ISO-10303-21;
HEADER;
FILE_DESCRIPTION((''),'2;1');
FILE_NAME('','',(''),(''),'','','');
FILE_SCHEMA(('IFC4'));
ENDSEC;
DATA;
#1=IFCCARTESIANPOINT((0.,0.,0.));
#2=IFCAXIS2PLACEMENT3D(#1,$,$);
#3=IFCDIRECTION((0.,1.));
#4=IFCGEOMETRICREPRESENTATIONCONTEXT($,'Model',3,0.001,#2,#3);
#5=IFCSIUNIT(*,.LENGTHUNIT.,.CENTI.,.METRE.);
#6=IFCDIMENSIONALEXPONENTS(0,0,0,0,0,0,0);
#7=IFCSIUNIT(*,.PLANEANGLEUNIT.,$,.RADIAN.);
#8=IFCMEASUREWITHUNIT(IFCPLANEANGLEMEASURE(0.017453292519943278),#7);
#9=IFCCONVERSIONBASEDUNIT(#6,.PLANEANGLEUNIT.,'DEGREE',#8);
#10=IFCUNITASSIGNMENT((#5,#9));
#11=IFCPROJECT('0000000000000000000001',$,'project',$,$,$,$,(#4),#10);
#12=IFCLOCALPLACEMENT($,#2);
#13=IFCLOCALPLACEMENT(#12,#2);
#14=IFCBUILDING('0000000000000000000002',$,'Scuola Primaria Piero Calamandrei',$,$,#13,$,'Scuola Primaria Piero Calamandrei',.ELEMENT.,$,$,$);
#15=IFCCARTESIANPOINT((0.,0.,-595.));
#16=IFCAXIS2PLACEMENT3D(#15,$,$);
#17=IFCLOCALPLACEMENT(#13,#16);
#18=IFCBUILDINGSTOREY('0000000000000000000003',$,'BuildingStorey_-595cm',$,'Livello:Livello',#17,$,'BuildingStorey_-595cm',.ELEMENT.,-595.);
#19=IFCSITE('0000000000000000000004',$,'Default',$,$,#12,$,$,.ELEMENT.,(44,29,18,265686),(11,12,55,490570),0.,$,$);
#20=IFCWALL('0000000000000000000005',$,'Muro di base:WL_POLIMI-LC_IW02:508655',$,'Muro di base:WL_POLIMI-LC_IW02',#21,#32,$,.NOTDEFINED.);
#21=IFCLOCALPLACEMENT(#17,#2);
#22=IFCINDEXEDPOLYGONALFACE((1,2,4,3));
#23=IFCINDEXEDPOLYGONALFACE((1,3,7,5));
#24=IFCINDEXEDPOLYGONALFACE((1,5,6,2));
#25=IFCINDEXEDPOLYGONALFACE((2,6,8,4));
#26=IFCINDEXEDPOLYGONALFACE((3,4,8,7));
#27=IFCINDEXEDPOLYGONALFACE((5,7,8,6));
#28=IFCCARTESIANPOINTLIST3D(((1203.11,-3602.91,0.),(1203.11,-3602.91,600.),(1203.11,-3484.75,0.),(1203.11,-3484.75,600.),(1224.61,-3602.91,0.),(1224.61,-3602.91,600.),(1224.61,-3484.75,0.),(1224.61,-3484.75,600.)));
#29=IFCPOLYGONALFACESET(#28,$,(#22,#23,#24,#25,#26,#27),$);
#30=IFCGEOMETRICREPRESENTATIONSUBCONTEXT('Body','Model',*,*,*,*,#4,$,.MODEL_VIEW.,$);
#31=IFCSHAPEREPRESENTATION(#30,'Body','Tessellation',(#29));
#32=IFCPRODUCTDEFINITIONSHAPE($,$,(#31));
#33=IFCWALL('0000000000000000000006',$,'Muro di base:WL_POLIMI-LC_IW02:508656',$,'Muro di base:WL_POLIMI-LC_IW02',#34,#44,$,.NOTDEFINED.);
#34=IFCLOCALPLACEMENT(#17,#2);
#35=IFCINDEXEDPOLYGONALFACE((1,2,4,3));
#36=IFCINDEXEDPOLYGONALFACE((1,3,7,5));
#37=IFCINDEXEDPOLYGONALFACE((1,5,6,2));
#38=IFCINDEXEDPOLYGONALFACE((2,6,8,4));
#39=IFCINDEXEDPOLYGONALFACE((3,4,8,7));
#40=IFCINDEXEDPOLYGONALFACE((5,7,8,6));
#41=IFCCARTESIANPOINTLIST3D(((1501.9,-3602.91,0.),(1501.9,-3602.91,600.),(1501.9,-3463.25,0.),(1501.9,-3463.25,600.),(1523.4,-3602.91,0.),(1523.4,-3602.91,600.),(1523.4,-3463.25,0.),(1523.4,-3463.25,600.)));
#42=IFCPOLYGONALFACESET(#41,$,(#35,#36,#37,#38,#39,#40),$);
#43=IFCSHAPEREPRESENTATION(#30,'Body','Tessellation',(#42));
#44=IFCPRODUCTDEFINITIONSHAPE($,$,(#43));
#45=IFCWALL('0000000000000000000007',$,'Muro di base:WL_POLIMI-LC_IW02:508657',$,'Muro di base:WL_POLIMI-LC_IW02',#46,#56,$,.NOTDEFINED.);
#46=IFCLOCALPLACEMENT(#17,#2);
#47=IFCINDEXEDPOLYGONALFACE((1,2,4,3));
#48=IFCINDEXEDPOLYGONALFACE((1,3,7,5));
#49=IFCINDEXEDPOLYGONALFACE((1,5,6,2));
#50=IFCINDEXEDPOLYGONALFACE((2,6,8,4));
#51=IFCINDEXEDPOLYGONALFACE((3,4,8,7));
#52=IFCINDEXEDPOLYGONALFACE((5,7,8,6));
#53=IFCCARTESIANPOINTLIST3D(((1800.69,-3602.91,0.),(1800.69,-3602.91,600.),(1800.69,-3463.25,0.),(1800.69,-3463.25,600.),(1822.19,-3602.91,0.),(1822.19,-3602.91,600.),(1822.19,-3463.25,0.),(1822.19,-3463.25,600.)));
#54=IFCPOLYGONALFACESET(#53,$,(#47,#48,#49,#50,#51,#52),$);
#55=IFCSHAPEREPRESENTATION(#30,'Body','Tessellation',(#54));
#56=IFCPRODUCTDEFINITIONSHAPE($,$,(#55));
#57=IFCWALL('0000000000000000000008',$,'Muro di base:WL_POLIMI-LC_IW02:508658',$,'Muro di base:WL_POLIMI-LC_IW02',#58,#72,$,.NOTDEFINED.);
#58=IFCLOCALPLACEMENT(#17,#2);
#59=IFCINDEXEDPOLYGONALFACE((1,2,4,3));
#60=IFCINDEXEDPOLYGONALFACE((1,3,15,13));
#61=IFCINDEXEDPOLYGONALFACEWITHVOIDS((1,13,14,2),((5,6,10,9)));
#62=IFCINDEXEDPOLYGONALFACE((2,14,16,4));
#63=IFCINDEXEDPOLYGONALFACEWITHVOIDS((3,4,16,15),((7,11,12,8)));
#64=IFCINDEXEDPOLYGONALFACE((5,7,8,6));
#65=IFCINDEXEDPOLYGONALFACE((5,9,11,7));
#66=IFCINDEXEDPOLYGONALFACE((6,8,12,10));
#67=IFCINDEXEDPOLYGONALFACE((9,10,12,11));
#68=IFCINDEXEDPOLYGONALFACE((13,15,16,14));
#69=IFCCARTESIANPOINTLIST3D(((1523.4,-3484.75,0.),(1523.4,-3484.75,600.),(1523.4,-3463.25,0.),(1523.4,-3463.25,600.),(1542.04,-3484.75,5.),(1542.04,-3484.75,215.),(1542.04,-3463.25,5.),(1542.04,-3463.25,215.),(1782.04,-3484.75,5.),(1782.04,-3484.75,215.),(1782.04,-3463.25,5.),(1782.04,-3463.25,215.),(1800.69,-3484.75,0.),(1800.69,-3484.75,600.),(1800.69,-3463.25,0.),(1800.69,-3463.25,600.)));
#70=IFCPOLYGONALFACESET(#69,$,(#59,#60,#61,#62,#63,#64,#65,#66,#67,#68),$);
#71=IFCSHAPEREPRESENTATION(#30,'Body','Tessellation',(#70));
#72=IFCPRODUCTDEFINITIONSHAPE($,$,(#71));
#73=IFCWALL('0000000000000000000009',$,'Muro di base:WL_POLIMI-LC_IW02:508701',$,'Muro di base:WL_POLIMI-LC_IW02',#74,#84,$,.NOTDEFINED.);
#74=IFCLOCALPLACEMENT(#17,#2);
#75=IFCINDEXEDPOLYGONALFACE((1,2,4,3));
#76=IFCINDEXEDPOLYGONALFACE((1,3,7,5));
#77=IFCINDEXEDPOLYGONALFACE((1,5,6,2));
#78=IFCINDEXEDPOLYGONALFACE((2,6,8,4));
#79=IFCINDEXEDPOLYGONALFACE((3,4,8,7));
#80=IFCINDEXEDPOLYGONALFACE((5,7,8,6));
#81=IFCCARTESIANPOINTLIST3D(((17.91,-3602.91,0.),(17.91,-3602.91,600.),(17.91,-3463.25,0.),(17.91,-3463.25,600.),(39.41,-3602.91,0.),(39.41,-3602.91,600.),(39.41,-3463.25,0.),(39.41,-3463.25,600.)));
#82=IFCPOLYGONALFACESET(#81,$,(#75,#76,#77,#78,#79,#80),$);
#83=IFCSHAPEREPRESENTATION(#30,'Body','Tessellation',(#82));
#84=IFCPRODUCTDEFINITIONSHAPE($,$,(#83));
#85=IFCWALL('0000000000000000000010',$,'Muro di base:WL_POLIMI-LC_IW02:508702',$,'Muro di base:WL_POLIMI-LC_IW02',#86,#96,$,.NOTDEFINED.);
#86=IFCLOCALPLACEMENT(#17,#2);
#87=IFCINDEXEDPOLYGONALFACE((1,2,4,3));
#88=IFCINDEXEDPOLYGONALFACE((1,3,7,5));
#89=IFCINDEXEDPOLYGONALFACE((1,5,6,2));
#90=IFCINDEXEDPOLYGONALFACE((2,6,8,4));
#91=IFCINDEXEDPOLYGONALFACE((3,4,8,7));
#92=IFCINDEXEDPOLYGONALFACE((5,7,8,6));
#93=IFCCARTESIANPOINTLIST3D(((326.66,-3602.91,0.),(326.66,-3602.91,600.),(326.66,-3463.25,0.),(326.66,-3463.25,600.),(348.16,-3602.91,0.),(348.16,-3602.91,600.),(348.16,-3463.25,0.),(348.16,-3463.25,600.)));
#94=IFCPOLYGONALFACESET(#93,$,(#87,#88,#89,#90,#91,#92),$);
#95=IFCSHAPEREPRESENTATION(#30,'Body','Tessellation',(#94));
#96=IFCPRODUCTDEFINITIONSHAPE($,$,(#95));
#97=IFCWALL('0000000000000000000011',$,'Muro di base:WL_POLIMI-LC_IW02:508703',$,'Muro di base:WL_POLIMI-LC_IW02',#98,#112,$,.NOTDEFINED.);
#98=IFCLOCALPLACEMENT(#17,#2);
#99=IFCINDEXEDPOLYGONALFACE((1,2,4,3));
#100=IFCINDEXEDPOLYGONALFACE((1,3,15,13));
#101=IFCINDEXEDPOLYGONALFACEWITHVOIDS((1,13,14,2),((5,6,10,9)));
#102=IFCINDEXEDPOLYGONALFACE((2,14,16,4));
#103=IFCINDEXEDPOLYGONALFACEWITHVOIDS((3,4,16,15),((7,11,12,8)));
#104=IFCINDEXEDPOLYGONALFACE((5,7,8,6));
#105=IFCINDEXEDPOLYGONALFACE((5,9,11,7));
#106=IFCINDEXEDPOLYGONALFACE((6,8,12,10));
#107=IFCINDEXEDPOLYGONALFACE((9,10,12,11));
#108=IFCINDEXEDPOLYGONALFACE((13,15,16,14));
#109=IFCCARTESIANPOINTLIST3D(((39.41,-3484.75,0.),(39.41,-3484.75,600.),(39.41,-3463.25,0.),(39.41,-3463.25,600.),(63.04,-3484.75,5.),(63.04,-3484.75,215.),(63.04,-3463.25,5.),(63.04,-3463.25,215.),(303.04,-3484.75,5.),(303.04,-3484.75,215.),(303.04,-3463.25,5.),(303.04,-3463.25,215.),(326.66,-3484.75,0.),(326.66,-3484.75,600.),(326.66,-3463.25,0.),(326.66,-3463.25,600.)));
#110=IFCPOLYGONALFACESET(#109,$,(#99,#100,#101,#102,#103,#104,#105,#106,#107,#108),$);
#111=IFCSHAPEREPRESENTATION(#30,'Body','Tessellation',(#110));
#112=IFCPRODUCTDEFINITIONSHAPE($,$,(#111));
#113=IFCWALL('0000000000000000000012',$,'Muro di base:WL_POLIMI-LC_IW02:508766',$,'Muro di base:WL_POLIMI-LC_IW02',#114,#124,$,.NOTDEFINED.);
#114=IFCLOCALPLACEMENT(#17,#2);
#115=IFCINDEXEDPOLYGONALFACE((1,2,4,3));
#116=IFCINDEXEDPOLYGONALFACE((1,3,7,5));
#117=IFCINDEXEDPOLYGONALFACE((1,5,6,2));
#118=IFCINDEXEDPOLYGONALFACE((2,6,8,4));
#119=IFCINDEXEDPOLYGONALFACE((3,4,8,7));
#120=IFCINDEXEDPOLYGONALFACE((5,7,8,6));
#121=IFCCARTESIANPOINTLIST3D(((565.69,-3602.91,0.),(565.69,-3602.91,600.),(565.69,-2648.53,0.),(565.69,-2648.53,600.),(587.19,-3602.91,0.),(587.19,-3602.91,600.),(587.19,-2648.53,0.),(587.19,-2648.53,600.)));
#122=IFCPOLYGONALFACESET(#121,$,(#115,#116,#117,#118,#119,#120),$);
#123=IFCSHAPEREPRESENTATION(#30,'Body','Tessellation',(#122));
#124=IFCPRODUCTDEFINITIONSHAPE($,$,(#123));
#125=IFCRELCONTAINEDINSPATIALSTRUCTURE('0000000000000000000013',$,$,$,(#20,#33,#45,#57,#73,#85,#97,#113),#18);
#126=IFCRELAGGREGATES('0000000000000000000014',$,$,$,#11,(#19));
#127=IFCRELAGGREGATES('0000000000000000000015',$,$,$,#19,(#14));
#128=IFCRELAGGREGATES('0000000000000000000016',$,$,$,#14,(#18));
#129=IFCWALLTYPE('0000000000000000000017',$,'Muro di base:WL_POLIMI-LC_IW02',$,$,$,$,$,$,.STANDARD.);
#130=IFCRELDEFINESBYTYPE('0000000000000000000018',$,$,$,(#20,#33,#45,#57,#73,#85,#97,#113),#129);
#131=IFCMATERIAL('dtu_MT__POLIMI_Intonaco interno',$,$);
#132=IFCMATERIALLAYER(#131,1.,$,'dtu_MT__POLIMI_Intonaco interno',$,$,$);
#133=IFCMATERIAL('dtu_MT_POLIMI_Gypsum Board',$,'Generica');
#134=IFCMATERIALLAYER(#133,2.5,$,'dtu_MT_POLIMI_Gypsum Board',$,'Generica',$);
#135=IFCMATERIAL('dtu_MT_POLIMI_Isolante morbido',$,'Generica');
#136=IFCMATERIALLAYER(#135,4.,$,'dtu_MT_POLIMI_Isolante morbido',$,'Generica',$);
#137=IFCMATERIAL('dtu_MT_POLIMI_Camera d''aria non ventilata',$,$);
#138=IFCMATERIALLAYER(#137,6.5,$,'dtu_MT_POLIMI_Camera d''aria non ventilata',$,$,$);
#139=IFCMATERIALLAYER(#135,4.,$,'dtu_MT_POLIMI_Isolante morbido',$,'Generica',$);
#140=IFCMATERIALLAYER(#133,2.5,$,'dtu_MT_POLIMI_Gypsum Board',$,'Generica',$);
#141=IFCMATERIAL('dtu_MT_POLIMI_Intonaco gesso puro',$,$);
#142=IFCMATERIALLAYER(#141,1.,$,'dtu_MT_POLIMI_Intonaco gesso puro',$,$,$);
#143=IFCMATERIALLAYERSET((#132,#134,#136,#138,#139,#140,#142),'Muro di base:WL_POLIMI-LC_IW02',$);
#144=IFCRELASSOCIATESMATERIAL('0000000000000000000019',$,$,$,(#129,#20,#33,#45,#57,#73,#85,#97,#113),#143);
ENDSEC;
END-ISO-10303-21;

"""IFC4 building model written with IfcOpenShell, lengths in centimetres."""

from ifc_helpers import new_model, entity, si_unit, converted_unit, direction, frame, frame_2d, origin, place, context, subcontext, project, spatial, rectangle, extrude, material, layer, layer_set, layer_usage, type_object, element, save


model = new_model("IFC4")

# Units and contexts
model_context = context("Model", 3, precision=0.001, world=origin(), true_north=direction((0.0, 1.0)))
body_context = subcontext(model_context, "Body", "Model", "MODEL_VIEW")
ifc_project = project(units=[si_unit("LENGTHUNIT", "METRE", prefix="CENTI"), converted_unit("PLANEANGLEUNIT", "DEGREE", entity("IfcPlaneAngleMeasure", 0.017453292519943278), si_unit("PLANEANGLEUNIT", "RADIAN"), dimensions=[0, 0, 0, 0, 0, 0, 0])], contexts=[model_context])

# Site, building, storey
site_placement = place(None, origin())
site = spatial("IfcSite", under=ifc_project, at=site_placement, Name="Default", CompositionType="ELEMENT", RefLatitude=(44, 29, 18, 265686), RefLongitude=(11, 12, 55, 490570), RefElevation=0.0)
building_placement = place(site_placement, origin())
building = spatial("IfcBuilding", under=site, at=building_placement, Name="Scuola Primaria Piero Calamandrei", LongName="Scuola Primaria Piero Calamandrei", CompositionType="ELEMENT")
storey_placement = place(building_placement, frame((0.0, 0.0, -595.0)))
storey = spatial("IfcBuildingStorey", under=building, at=storey_placement, Name="BuildingStorey_-595cm", ObjectType="Livello:Livello", LongName="BuildingStorey_-595cm", CompositionType="ELEMENT", Elevation=-595.0)

# Shared definitions
ifc_material_1 = material(Name="dtu_MT__POLIMI_Intonaco interno")
ifc_material_2 = material(Name="dtu_MT_POLIMI_Isolante morbido", Category="Generica")
ifc_material_3 = material(Name="dtu_MT_POLIMI_Gypsum Board", Category="Generica")

# Shared definitions
ifc_layer_1 = layer(ifc_material_1, 1.0, Name="dtu_MT__POLIMI_Intonaco interno")
ifc_layer_2 = layer(ifc_material_3, 2.5, Name="dtu_MT_POLIMI_Gypsum Board", Category="Generica")
ifc_layer_3 = layer(ifc_material_2, 4.0, Name="dtu_MT_POLIMI_Isolante morbido", Category="Generica")
ifc_material_4 = material(Name="dtu_MT_POLIMI_Camera d'aria non ventilata")
ifc_layer_4 = layer(ifc_material_4, 6.5, Name="dtu_MT_POLIMI_Camera d'aria non ventilata")
ifc_layer_5 = layer(ifc_material_2, 4.0, Name="dtu_MT_POLIMI_Isolante morbido", Category="Generica")
ifc_layer_6 = layer(ifc_material_3, 2.5, Name="dtu_MT_POLIMI_Gypsum Board", Category="Generica")
ifc_material_5 = material(Name="dtu_MT_POLIMI_Intonaco gesso puro")
ifc_layer_7 = layer(ifc_material_5, 1.0, Name="dtu_MT_POLIMI_Intonaco gesso puro")
ifc_layer_set_1 = layer_set([ifc_layer_1, ifc_layer_2, ifc_layer_3, ifc_layer_4, ifc_layer_5, ifc_layer_6, ifc_layer_7], Name="Muro di base:WL_POLIMI-LC_IW02")
wall_type_1 = type_object("IfcWallType", Name="Muro di base:WL_POLIMI-LC_IW02", PredefinedType="STANDARD", material=ifc_layer_set_1)

# Walls
ifc_layer_usage_1 = layer_usage(ifc_layer_set_1, "AXIS2", "NEGATIVE", 10.75)
wall_1_placement = place(storey_placement, frame((1213.86, -3484.75, 0.0), z_axis=(0.0, 0.0, 1.0), x_axis=(0.0, -1.0, 0.0)))
element("IfcWall", 1, at=wall_1_placement, inside=storey, type_object=wall_type_1, material=ifc_layer_usage_1, Name="Muro di base:WL_POLIMI-LC_IW02:508655", ObjectType="Muro di base:WL_POLIMI-LC_IW02", PredefinedType="NOTDEFINED", context=body_context, shape_type="SweptSolid", body=[
    extrude(rectangle(XDim=118.16, YDim=21.5, at=frame_2d((59.08, 0.0), x_axis=(-1.0, 0.0))), origin(), (0.0, 0.0, 1.0), 600.0),
])
ifc_layer_usage_2 = layer_usage(ifc_layer_set_1, "AXIS2", "NEGATIVE", 10.75)
wall_2_placement = place(storey_placement, frame((1512.65, -3602.91, 0.0), z_axis=(0.0, 0.0, 1.0), x_axis=(0.0, 1.0, 0.0)))
element("IfcWall", 2, at=wall_2_placement, inside=storey, type_object=wall_type_1, material=ifc_layer_usage_2, Name="Muro di base:WL_POLIMI-LC_IW02:508656", ObjectType="Muro di base:WL_POLIMI-LC_IW02", PredefinedType="NOTDEFINED", context=body_context, shape_type="SweptSolid", body=[
    extrude(rectangle(XDim=139.66, YDim=21.5, at=frame_2d((69.83, 0.0), x_axis=(-1.0, 0.0))), origin(), (0.0, 0.0, 1.0), 600.0),
])
ifc_layer_usage_3 = layer_usage(ifc_layer_set_1, "AXIS2", "NEGATIVE", 10.75)
wall_3_placement = place(storey_placement, frame((1811.44, -3463.25, 0.0), z_axis=(0.0, 0.0, 1.0), x_axis=(0.0, -1.0, 0.0)))
element("IfcWall", 3, at=wall_3_placement, inside=storey, type_object=wall_type_1, material=ifc_layer_usage_3, Name="Muro di base:WL_POLIMI-LC_IW02:508657", ObjectType="Muro di base:WL_POLIMI-LC_IW02", PredefinedType="NOTDEFINED", context=body_context, shape_type="SweptSolid", body=[
    extrude(rectangle(XDim=139.66, YDim=21.5, at=frame_2d((69.83, 0.0), x_axis=(-1.0, 0.0))), origin(), (0.0, 0.0, 1.0), 600.0),
])

# Wall, opening
ifc_layer_usage_4 = layer_usage(ifc_layer_set_1, "AXIS2", "NEGATIVE", 10.75)
wall_4_placement = place(storey_placement, frame((1523.4, -3474.0, 0.0)))
wall_4 = element("IfcWall", 4, at=wall_4_placement, inside=storey, type_object=wall_type_1, material=ifc_layer_usage_4, Name="Muro di base:WL_POLIMI-LC_IW02:508658", ObjectType="Muro di base:WL_POLIMI-LC_IW02", PredefinedType="NOTDEFINED", context=body_context, shape_type="SweptSolid", body=[
    extrude(rectangle(XDim=277.29, YDim=21.5, at=frame_2d((138.64, 0.0), x_axis=(-1.0, 0.0))), origin(), (0.0, 0.0, 1.0), 600.0),
])
opening_1_placement = place(wall_4_placement, frame((258.64, 10.75, 5.0)))
element("IfcOpeningElement", 5, at=opening_1_placement, cuts=wall_4, PredefinedType="OPENING", context=body_context, shape_type="SweptSolid", body=[
    extrude(rectangle(XDim=210.0, YDim=240.0, at=frame_2d((105.0, 120.0), x_axis=(-1.0, 0.0))), frame((0.0, 0.0, 0.0), z_axis=(0.0, -1.0, 0.0), x_axis=(0.0, 0.0, 1.0)), (0.0, 0.0, 1.0), 21.5),
])

# Walls
ifc_layer_usage_5 = layer_usage(ifc_layer_set_1, "AXIS2", "NEGATIVE", 10.75)
wall_5_placement = place(storey_placement, frame((28.66, -3602.91, 0.0), z_axis=(0.0, 0.0, 1.0), x_axis=(0.0, 1.0, 0.0)))
element("IfcWall", 6, at=wall_5_placement, inside=storey, type_object=wall_type_1, material=ifc_layer_usage_5, Name="Muro di base:WL_POLIMI-LC_IW02:508701", ObjectType="Muro di base:WL_POLIMI-LC_IW02", PredefinedType="NOTDEFINED", context=body_context, shape_type="SweptSolid", body=[
    extrude(rectangle(XDim=139.66, YDim=21.5, at=frame_2d((69.83, 0.0), x_axis=(-1.0, 0.0))), origin(), (0.0, 0.0, 1.0), 600.0),
])
ifc_layer_usage_6 = layer_usage(ifc_layer_set_1, "AXIS2", "NEGATIVE", 10.75)
wall_6_placement = place(storey_placement, frame((337.41, -3463.25, 0.0), z_axis=(0.0, 0.0, 1.0), x_axis=(0.0, -1.0, 0.0)))
element("IfcWall", 7, at=wall_6_placement, inside=storey, type_object=wall_type_1, material=ifc_layer_usage_6, Name="Muro di base:WL_POLIMI-LC_IW02:508702", ObjectType="Muro di base:WL_POLIMI-LC_IW02", PredefinedType="NOTDEFINED", context=body_context, shape_type="SweptSolid", body=[
    extrude(rectangle(XDim=139.66, YDim=21.5, at=frame_2d((69.83, 0.0), x_axis=(-1.0, 0.0))), origin(), (0.0, 0.0, 1.0), 600.0),
])

# Wall, opening
ifc_layer_usage_7 = layer_usage(ifc_layer_set_1, "AXIS2", "NEGATIVE", 10.75)
wall_7_placement = place(storey_placement, frame((39.41, -3474.0, 0.0)))
wall_7 = element("IfcWall", 8, at=wall_7_placement, inside=storey, type_object=wall_type_1, material=ifc_layer_usage_7, Name="Muro di base:WL_POLIMI-LC_IW02:508703", ObjectType="Muro di base:WL_POLIMI-LC_IW02", PredefinedType="NOTDEFINED", context=body_context, shape_type="SweptSolid", body=[
    extrude(rectangle(XDim=287.25, YDim=21.5, at=frame_2d((143.62, 0.0), x_axis=(-1.0, 0.0))), origin(), (0.0, 0.0, 1.0), 600.0),
])
opening_2_placement = place(wall_7_placement, frame((263.62, 10.75, 5.0)))
element("IfcOpeningElement", 9, at=opening_2_placement, cuts=wall_7, PredefinedType="OPENING", context=body_context, shape_type="SweptSolid", body=[
    extrude(rectangle(XDim=210.0, YDim=240.0, at=frame_2d((105.0, 120.0), x_axis=(-1.0, 0.0))), frame((0.0, 0.0, 0.0), z_axis=(0.0, -1.0, 0.0), x_axis=(0.0, 0.0, 1.0)), (0.0, 0.0, 1.0), 21.5),
])

# Wall
ifc_layer_usage_8 = layer_usage(ifc_layer_set_1, "AXIS2", "NEGATIVE", 10.75)
wall_8_placement = place(storey_placement, frame((576.44, -3602.91, 0.0), z_axis=(0.0, 0.0, 1.0), x_axis=(0.0, 1.0, 0.0)))
element("IfcWall", 10, at=wall_8_placement, inside=storey, type_object=wall_type_1, material=ifc_layer_usage_8, Name="Muro di base:WL_POLIMI-LC_IW02:508766", ObjectType="Muro di base:WL_POLIMI-LC_IW02", PredefinedType="NOTDEFINED", context=body_context, shape_type="SweptSolid", body=[
    extrude(rectangle(XDim=954.38, YDim=21.5, at=frame_2d((477.19, 0.0), x_axis=(-1.0, 0.0))), origin(), (0.0, 0.0, 1.0), 600.0),
])

save(model, "model.ifc")
